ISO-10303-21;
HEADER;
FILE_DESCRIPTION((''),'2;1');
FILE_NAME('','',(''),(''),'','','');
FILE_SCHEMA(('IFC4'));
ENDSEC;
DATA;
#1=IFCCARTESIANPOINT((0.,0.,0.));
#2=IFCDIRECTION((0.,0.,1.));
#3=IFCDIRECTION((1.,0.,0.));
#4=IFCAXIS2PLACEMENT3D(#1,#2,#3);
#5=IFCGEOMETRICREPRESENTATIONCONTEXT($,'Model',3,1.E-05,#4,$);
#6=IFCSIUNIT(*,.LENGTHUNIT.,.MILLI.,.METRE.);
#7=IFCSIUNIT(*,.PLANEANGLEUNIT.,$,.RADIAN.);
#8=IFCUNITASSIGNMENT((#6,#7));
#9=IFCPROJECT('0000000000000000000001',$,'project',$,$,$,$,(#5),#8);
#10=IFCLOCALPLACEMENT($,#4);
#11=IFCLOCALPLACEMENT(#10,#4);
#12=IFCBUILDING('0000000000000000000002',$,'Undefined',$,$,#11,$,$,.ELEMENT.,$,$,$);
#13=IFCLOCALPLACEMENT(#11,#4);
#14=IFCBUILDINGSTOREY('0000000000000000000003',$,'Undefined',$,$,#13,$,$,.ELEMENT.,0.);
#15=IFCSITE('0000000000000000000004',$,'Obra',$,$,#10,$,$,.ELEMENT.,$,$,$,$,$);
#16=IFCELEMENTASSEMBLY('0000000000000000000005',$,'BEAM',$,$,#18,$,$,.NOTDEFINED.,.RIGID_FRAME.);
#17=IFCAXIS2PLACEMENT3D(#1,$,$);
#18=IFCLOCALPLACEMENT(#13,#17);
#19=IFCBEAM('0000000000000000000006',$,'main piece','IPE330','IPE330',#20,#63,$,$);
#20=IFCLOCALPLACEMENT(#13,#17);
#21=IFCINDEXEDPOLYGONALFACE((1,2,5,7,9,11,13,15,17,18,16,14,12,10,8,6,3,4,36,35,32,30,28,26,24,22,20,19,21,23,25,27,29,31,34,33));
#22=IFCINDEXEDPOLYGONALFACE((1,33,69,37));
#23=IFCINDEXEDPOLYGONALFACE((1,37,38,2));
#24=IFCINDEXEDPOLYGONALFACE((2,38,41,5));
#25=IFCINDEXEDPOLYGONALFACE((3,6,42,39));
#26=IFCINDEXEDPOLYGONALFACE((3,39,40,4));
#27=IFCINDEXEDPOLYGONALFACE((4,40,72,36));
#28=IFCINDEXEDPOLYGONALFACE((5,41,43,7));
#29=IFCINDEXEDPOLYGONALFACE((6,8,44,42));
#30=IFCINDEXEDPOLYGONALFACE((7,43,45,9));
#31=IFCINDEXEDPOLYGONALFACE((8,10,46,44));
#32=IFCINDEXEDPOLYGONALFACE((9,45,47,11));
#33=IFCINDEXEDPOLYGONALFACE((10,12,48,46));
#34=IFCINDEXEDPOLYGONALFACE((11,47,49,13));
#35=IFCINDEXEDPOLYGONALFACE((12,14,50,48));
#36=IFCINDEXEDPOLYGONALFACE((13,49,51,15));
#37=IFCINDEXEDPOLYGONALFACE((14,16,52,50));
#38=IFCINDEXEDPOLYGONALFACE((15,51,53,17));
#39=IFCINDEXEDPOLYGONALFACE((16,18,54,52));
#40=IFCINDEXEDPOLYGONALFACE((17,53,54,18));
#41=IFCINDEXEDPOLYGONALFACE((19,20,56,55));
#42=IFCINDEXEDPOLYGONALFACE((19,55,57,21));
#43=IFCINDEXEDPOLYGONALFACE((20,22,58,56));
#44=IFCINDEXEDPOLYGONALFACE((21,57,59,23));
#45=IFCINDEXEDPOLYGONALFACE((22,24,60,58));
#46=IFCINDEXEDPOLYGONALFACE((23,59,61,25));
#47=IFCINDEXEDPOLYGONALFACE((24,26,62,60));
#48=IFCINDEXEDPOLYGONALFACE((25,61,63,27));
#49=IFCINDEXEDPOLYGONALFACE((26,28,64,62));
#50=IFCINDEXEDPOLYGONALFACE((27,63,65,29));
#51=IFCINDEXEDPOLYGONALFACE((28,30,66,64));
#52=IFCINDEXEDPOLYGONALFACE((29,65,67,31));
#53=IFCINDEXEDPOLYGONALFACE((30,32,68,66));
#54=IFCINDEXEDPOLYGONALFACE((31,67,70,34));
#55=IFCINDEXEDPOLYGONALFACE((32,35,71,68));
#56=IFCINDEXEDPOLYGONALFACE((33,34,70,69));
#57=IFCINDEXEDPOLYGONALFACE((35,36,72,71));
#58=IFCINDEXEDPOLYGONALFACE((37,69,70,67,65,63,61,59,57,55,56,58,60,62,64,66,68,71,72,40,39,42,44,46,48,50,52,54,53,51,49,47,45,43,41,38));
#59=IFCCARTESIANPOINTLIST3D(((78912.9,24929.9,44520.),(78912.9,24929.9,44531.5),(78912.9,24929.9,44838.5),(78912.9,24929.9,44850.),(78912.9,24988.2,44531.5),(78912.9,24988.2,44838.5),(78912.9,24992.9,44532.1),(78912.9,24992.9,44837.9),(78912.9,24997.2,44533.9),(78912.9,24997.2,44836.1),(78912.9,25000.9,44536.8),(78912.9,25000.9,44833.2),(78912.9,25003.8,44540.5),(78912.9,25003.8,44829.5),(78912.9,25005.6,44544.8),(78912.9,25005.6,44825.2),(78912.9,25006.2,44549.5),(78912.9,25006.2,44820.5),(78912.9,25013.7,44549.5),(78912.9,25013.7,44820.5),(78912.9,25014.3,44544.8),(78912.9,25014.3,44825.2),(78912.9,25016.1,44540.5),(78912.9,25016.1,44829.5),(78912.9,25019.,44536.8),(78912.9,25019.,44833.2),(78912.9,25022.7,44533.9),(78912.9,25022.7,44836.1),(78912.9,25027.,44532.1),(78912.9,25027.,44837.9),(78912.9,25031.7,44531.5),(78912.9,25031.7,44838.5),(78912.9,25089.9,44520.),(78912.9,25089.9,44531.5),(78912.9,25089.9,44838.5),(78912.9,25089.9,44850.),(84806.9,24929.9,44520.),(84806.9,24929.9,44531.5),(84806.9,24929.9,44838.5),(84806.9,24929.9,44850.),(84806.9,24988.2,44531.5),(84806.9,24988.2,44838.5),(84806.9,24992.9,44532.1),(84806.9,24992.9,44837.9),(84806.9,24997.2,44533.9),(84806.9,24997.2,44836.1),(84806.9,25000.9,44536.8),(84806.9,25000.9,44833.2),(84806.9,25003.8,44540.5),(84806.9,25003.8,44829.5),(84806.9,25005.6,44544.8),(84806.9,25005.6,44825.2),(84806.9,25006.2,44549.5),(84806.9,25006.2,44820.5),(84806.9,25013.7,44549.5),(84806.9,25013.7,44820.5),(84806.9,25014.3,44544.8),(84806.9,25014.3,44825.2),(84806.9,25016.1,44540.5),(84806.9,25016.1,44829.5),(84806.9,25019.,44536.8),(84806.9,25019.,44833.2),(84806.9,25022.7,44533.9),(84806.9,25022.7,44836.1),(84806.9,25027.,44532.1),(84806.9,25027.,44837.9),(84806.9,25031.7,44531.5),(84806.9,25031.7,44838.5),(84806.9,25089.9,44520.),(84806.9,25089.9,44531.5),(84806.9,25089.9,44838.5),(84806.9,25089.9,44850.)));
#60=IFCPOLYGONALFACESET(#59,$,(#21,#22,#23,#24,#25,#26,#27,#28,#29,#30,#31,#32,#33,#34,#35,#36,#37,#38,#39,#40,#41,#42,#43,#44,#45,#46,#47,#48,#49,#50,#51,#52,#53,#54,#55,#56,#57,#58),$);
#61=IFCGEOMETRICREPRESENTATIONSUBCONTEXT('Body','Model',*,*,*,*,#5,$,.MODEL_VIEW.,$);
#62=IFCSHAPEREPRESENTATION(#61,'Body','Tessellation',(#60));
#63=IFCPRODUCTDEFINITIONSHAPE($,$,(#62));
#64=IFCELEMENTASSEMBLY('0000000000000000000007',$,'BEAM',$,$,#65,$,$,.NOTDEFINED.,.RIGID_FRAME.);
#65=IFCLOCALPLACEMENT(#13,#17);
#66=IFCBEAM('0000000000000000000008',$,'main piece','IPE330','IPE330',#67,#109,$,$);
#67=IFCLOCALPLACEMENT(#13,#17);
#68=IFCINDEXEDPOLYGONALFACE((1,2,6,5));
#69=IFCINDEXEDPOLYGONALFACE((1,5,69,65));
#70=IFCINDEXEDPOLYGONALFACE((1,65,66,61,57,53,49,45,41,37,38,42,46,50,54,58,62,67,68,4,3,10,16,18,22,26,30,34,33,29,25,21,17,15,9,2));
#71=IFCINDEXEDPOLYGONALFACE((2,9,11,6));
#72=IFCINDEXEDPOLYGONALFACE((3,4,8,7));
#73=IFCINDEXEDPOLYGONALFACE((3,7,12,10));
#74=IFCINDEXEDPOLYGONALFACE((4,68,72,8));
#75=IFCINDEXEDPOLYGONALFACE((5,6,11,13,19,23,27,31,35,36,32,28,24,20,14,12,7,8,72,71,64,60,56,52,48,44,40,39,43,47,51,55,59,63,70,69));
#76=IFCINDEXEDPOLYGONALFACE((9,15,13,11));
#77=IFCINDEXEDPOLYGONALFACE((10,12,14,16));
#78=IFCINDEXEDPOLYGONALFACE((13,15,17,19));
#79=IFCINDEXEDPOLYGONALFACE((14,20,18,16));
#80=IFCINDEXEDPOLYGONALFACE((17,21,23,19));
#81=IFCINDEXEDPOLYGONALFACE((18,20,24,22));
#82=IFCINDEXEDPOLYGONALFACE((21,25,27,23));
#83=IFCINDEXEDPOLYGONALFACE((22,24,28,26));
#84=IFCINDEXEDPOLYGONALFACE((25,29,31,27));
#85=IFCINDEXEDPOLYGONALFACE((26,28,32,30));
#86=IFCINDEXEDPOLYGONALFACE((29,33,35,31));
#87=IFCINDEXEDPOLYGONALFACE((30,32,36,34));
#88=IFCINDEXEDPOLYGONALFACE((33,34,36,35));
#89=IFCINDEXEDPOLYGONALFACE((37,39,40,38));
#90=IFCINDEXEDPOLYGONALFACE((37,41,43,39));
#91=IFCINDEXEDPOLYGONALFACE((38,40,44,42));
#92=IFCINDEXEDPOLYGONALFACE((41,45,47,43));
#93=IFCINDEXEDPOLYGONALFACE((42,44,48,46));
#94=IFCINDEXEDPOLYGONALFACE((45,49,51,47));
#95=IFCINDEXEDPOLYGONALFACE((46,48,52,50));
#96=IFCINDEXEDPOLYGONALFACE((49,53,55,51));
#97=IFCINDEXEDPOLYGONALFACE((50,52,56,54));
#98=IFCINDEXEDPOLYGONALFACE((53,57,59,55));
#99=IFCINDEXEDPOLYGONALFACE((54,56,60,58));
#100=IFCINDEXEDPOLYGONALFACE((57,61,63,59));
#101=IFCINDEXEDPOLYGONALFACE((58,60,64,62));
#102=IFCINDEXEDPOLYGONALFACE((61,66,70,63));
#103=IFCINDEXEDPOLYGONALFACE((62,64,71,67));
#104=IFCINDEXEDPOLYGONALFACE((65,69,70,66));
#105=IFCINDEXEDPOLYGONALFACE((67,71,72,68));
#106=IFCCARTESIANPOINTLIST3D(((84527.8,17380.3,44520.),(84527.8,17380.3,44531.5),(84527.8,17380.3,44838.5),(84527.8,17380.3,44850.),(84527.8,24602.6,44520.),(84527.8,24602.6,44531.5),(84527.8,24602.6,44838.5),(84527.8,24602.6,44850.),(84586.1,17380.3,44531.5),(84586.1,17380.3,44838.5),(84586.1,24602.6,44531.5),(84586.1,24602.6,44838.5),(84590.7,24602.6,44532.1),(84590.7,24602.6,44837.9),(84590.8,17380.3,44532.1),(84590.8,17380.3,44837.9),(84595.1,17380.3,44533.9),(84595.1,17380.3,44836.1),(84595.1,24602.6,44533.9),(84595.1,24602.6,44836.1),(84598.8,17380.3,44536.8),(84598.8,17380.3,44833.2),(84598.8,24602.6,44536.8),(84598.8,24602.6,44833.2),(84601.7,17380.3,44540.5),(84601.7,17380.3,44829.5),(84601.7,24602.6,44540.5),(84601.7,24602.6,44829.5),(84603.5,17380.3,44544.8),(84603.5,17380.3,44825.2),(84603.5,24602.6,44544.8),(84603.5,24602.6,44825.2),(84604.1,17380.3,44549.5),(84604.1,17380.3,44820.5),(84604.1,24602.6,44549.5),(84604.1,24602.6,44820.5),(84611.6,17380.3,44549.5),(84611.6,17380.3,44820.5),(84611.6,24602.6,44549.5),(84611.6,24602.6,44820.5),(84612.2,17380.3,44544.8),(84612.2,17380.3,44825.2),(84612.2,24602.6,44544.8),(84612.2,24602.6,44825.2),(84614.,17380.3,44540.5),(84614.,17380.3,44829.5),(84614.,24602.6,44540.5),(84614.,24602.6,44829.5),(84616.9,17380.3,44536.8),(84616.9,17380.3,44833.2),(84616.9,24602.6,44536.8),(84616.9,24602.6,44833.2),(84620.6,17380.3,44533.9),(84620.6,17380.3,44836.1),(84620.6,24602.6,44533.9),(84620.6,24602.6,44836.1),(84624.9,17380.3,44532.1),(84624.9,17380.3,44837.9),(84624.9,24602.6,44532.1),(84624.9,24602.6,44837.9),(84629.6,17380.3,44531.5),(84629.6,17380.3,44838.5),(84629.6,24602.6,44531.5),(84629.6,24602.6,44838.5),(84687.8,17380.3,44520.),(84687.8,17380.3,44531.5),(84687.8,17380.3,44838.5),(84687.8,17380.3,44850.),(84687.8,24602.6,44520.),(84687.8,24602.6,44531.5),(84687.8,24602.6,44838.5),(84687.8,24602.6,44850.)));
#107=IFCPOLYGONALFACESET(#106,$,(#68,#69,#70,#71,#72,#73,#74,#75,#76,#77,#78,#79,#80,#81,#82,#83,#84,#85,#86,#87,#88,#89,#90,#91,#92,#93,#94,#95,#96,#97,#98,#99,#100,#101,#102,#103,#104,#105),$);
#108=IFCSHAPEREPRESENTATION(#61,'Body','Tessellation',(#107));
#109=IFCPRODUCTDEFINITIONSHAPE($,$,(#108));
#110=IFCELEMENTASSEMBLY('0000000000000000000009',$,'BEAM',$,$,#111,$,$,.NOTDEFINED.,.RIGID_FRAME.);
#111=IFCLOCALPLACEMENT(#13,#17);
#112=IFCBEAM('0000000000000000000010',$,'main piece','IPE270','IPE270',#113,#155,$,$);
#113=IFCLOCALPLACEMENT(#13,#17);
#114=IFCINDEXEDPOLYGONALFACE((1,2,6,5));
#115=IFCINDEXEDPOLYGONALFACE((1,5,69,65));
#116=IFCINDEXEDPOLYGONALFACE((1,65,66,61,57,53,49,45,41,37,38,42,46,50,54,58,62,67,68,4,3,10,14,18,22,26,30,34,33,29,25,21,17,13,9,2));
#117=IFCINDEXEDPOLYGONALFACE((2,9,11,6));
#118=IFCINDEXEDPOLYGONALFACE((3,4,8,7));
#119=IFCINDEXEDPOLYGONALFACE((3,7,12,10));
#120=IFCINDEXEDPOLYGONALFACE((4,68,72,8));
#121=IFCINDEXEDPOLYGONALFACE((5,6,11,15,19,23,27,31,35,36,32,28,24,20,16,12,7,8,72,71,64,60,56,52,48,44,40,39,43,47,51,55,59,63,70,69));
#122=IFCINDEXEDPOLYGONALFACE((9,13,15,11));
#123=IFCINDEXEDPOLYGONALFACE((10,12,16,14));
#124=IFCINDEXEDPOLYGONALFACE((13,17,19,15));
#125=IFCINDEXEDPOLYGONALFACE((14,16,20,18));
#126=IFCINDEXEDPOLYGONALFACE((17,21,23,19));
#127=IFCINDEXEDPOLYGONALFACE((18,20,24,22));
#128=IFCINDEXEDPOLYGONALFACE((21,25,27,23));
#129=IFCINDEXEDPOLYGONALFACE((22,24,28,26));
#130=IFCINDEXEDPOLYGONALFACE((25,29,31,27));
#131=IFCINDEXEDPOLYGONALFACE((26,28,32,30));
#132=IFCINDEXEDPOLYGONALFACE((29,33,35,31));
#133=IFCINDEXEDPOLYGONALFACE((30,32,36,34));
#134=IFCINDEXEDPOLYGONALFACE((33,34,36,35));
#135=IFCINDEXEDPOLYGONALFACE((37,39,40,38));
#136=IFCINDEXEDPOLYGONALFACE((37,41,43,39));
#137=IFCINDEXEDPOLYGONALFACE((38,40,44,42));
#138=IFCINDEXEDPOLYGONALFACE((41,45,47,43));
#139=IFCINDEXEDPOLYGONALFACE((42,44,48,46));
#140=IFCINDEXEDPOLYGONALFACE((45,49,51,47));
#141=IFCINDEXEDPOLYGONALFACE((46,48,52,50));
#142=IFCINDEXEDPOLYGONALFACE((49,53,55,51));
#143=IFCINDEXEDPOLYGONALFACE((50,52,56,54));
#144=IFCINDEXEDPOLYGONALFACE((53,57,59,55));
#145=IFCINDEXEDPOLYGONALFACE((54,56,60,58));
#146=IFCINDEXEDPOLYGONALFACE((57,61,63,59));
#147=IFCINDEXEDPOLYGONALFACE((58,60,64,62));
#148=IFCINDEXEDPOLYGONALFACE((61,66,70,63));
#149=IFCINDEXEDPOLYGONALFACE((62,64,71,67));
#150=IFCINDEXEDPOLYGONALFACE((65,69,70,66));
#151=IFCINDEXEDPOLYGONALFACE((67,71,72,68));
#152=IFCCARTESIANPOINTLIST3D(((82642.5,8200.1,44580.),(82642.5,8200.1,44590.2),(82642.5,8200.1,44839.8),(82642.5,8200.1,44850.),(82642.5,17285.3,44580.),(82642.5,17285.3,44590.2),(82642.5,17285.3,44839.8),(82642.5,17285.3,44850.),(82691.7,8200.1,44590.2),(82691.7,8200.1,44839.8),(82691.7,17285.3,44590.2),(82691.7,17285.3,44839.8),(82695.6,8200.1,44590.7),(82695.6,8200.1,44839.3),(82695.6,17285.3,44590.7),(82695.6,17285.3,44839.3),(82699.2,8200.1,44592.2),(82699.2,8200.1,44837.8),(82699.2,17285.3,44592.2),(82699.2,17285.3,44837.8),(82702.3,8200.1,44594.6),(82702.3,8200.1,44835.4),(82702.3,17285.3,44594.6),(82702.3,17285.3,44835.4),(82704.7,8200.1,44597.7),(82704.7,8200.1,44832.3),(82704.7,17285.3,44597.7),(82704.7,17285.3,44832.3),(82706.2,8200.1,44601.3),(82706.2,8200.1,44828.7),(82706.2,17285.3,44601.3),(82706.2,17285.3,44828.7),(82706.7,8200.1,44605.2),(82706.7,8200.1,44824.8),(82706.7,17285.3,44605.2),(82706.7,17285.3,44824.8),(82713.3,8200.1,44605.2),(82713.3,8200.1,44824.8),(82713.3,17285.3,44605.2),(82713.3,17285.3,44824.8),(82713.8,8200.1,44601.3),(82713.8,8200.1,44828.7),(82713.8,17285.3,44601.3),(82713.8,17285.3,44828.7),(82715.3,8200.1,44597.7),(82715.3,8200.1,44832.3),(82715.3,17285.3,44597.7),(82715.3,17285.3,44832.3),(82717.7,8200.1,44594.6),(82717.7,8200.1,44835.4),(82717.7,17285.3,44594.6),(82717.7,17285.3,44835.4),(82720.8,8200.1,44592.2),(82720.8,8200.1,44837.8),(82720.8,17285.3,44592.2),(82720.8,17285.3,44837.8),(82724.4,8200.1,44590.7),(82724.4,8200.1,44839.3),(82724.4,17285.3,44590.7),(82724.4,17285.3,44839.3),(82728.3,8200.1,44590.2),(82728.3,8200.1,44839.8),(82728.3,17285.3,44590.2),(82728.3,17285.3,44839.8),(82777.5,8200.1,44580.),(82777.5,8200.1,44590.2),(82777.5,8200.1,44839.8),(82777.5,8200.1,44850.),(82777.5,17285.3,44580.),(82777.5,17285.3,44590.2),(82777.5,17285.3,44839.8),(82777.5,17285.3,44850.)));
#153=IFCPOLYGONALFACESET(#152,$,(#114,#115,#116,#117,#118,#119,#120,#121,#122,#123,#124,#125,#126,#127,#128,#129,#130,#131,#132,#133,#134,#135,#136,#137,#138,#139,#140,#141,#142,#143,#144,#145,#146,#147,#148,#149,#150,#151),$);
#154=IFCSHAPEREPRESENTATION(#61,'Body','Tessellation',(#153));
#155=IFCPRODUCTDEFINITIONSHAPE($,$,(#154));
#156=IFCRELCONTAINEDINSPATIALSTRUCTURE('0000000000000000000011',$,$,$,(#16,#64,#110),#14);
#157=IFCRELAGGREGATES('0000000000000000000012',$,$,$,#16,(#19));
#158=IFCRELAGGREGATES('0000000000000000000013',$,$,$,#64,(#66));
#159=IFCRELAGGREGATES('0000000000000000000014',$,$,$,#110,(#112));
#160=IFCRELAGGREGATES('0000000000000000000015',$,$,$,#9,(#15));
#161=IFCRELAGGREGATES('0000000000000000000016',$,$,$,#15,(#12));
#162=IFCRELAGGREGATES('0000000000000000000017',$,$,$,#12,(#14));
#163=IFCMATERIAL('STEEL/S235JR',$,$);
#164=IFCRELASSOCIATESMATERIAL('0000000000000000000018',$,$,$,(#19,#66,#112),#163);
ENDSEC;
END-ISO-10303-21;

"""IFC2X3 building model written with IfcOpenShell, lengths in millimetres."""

from ifc_helpers import new_model, si_unit, frame, origin_with_axes, origin_2d_with_axis, place, context, subcontext, project, spatial, i_section, extrude, material, element, aggregate, save


model = new_model("IFC2X3")

# Units and contexts
model_context = context("Model", 3, precision=1e-05, world=origin_with_axes())
body_context = subcontext(model_context, "Body", "Model", "MODEL_VIEW")
ifc_project = project(units=[si_unit("LENGTHUNIT", "METRE", prefix="MILLI"), si_unit("PLANEANGLEUNIT", "RADIAN")], contexts=[model_context])

# Site, building, storey
site_placement = place(None, origin_with_axes())
site = spatial("IfcSite", under=ifc_project, at=site_placement, Name="Obra", CompositionType="ELEMENT")
building_placement = place(site_placement, origin_with_axes())
building = spatial("IfcBuilding", under=site, at=building_placement, Name="Undefined", CompositionType="ELEMENT")
storey_placement = place(building_placement, origin_with_axes())
storey = spatial("IfcBuildingStorey", under=building, at=storey_placement, Name="Undefined", CompositionType="ELEMENT", Elevation=0.0)

# Shared definitions
ifc_material = material(Name="STEEL/S235JR")

# Element assemblies, beams
assembly_1_placement = place(storey_placement, origin_with_axes())
assembly_1 = element("IfcElementAssembly", 1, at=assembly_1_placement, inside=storey, Name="BEAM", AssemblyPlace="NOTDEFINED", PredefinedType="RIGID_FRAME")
beam_1_placement = place(assembly_1_placement, frame((78912.9, 25009.9, 44685.0), z_axis=(0.0, 0.0, 1.0), x_axis=(1.0, 0.0, 0.0)))
beam_1 = element("IfcBeam", 2, at=beam_1_placement, material=ifc_material, Name="main piece", Description="IPE330", ObjectType="IPE330", context=body_context, shape_type="SweptSolid", body=[
    extrude(i_section(OverallWidth=160.0, OverallDepth=330.0, WebThickness=7.5, FlangeThickness=11.5, FilletRadius=18.0, at=origin_2d_with_axis()), frame((5894.0, 0.0, 0.0), z_axis=(-1.0, 0.0, 0.0), x_axis=(0.0, -1.0, 0.0)), (0.0, 0.0, 1.0), 5894.0),
])
aggregate(assembly_1, [beam_1])
assembly_2_placement = place(storey_placement, origin_with_axes())
assembly_2 = element("IfcElementAssembly", 3, at=assembly_2_placement, inside=storey, Name="BEAM", AssemblyPlace="NOTDEFINED", PredefinedType="RIGID_FRAME")
beam_2_placement = place(assembly_2_placement, frame((84607.8, 17380.3, 44685.0), z_axis=(0.0, 0.0, 1.0), x_axis=(-0.000002, 1.0, 0.0)))
beam_2 = element("IfcBeam", 4, at=beam_2_placement, material=ifc_material, Name="main piece", Description="IPE330", ObjectType="IPE330", context=body_context, shape_type="SweptSolid", body=[
    extrude(i_section(OverallWidth=160.0, OverallDepth=330.0, WebThickness=7.5, FlangeThickness=11.5, FilletRadius=18.0, at=origin_2d_with_axis()), frame((7222.3, 0.0, 0.0), z_axis=(-1.0, 0.0, 0.0), x_axis=(0.0, -1.0, 0.0)), (0.0, 0.0, 1.0), 7222.3),
])
aggregate(assembly_2, [beam_2])
assembly_3_placement = place(storey_placement, origin_with_axes())
assembly_3 = element("IfcElementAssembly", 5, at=assembly_3_placement, inside=storey, Name="BEAM", AssemblyPlace="NOTDEFINED", PredefinedType="RIGID_FRAME")
beam_3_placement = place(assembly_3_placement, frame((82710.0, 17285.3, 44715.0), z_axis=(0.0, 0.0, 1.0), x_axis=(0.0, -1.0, 0.0)))
beam_3 = element("IfcBeam", 6, at=beam_3_placement, material=ifc_material, Name="main piece", Description="IPE270", ObjectType="IPE270", context=body_context, shape_type="SweptSolid", body=[
    extrude(i_section(OverallWidth=135.0, OverallDepth=270.0, WebThickness=6.6, FlangeThickness=10.2, FilletRadius=15.0, at=origin_2d_with_axis()), frame((9085.2, 0.0, 0.0), z_axis=(-1.0, 0.0, 0.0), x_axis=(0.0, -1.0, 0.0)), (0.0, 0.0, 1.0), 9085.2),
])
aggregate(assembly_3, [beam_3])

save(model, "model.ifc")
